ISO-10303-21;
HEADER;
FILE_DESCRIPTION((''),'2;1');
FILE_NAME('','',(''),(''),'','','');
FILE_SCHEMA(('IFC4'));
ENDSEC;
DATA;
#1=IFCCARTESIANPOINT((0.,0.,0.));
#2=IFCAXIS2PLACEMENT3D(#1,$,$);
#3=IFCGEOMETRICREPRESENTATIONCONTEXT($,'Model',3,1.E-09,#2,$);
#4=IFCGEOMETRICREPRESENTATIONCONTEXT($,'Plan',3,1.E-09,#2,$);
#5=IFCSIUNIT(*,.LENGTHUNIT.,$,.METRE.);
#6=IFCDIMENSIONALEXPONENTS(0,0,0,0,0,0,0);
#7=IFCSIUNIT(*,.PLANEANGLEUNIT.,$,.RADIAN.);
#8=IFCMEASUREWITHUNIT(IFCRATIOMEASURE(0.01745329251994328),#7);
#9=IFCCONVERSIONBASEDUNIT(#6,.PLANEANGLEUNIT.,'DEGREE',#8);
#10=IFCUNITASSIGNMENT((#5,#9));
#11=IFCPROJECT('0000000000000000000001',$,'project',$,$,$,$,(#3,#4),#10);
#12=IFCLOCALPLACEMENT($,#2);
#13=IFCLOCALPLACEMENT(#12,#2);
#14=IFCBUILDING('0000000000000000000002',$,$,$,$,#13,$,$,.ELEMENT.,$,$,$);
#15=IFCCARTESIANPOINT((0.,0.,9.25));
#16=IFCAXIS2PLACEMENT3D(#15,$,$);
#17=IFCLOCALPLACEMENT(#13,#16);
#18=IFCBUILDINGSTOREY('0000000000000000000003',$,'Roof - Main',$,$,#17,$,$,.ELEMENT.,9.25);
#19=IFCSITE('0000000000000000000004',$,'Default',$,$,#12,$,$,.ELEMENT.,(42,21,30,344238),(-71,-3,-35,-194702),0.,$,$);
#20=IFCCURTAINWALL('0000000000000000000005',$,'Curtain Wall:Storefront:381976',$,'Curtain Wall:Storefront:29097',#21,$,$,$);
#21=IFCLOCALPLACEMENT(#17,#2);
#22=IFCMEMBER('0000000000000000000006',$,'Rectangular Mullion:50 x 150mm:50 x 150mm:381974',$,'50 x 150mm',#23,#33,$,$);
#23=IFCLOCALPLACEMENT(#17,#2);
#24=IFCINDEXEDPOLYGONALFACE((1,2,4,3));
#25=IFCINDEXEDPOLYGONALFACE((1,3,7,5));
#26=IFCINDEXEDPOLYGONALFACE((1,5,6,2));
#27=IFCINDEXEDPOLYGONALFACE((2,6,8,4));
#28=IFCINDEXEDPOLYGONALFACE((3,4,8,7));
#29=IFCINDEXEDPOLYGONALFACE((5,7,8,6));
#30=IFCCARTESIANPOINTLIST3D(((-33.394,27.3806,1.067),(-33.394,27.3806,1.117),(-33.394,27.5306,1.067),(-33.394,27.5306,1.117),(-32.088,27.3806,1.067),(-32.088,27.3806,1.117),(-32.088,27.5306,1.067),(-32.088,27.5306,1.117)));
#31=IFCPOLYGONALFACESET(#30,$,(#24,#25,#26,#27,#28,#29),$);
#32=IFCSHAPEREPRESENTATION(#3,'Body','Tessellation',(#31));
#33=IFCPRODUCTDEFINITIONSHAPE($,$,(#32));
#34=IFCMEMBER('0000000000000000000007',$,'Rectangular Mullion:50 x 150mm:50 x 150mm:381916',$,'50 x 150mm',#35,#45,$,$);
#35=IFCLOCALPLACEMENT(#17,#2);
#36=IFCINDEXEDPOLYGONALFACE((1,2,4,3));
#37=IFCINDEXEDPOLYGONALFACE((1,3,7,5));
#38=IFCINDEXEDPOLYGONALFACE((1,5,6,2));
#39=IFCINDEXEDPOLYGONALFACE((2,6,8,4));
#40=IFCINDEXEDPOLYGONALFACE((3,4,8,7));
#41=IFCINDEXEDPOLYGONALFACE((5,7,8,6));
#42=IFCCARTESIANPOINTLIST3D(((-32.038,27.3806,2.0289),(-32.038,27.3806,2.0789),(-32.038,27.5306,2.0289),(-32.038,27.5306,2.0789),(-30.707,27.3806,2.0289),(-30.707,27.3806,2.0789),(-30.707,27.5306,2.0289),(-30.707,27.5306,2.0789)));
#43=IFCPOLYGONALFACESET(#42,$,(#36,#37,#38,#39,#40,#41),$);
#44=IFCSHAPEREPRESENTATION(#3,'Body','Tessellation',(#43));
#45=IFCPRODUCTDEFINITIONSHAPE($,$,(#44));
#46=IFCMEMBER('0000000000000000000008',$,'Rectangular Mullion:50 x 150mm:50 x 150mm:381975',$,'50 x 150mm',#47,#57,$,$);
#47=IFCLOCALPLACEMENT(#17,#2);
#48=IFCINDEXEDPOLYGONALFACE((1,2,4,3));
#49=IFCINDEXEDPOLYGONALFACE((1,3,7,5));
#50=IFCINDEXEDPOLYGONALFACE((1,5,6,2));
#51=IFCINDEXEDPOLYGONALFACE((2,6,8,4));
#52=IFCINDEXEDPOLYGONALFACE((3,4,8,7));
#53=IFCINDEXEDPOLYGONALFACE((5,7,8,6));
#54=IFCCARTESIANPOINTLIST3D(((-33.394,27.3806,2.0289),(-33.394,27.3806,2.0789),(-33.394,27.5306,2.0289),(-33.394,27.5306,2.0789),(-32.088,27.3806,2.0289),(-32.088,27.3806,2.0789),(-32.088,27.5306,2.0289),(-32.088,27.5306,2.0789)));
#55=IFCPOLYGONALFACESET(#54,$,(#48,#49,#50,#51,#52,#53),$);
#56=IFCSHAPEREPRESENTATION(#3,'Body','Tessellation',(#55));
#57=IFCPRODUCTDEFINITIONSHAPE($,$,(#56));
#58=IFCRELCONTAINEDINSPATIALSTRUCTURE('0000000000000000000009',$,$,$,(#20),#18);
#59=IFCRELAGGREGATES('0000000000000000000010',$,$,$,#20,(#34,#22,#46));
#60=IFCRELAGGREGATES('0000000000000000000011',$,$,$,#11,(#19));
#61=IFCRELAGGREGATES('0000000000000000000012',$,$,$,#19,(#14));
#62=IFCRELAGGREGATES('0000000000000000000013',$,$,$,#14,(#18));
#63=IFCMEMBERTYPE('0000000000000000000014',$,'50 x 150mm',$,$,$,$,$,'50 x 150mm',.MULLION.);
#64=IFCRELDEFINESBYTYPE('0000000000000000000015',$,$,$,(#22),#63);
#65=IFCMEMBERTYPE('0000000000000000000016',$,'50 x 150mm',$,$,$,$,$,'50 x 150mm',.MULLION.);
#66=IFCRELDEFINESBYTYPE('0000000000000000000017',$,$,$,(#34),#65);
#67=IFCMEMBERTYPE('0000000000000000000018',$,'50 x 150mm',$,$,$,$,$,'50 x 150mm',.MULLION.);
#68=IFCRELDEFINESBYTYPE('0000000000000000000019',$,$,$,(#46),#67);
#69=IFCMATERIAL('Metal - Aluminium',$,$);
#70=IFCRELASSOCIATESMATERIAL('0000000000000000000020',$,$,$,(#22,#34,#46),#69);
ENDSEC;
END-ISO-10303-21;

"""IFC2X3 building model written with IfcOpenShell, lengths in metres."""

from ifc_helpers import new_model, entity, si_unit, converted_unit, frame, origin, origin_2d_with_axis, place, context, project, spatial, rectangle, extrude, source, transform, mapped, material, type_object, type_shapes, element, aggregate, save


model = new_model("IFC2X3")

# Units and contexts
model_context = context("Model", 3, precision=1e-09, world=origin())
plan_context = context("Plan", 3, precision=1e-09, world=origin())
ifc_project = project(units=[si_unit("LENGTHUNIT", "METRE"), converted_unit("PLANEANGLEUNIT", "DEGREE", entity("IfcRatioMeasure", 0.01745329251994328), si_unit("PLANEANGLEUNIT", "RADIAN"), dimensions=[0, 0, 0, 0, 0, 0, 0])], contexts=[model_context, plan_context])

# Site, building, storey
site_placement = place(None, origin())
site = spatial("IfcSite", under=ifc_project, at=site_placement, Name="Default", CompositionType="ELEMENT", RefLatitude=(42, 21, 30, 344238), RefLongitude=(-71, -3, -35, -194702), RefElevation=0.0)
building_placement = place(site_placement, origin())
building = spatial("IfcBuilding", under=site, at=building_placement, CompositionType="ELEMENT")
storey_placement = place(building_placement, frame((0.0, 0.0, 9.25)))
storey = spatial("IfcBuildingStorey", under=building, at=storey_placement, Name="Roof - Main", CompositionType="ELEMENT", Elevation=9.25)

# Curtain wall
curtain_wall_1_placement = place(storey_placement, origin())
curtain_wall_1 = element("IfcCurtainWall", 1, at=curtain_wall_1_placement, inside=storey, Name="Curtain Wall:Storefront:381976", ObjectType="Curtain Wall:Storefront:29097")
ifc_material_1 = material(Name="Metal - Aluminium")

# Members
member_type_1 = type_object("IfcMemberType", Name="50 x 150mm", ElementType="50 x 150mm", PredefinedType="MULLION")
shared_shape_1 = source(origin(), model_context, "Body", "SweptSolid", [
    extrude(rectangle(XDim=0.05, YDim=0.15, at=origin_2d_with_axis()), frame((-0.025, 0.0, -1.306), z_axis=(0.0, 0.0, 1.0), x_axis=(-1.0, 0.0, 0.0)), (0.0, 0.0, 1.0), 1.306),
])
type_shapes(member_type_1, [shared_shape_1])
member_1_placement = place(storey_placement, frame((-33.394, 27.4556, 1.067), z_axis=(-1.0, 0.0, 0.0), x_axis=(0.0, 0.0, -1.0)))
member_1 = element("IfcMember", 2, at=member_1_placement, type_object=member_type_1, material=ifc_material_1, Name="Rectangular Mullion:50 x 150mm:50 x 150mm:381974", ObjectType="50 x 150mm", context=model_context, shape_type="MappedRepresentation", body=[
    mapped(shared_shape_1, transform((0.0, 0.0, 0.0), scale=1.0)),
])
member_type_2 = type_object("IfcMemberType", Name="50 x 150mm", ElementType="50 x 150mm", PredefinedType="MULLION")
shared_shape_2 = source(origin(), model_context, "Body", "SweptSolid", [
    extrude(rectangle(XDim=0.05, YDim=0.15, at=origin_2d_with_axis()), frame((0.0, 0.0, -1.331), z_axis=(0.0, 0.0, 1.0), x_axis=(-1.0, 0.0, 0.0)), (0.0, 0.0, 1.0), 1.331),
])
type_shapes(member_type_2, [shared_shape_2])
member_2_placement = place(storey_placement, frame((-30.707, 27.4556, 2.0539), z_axis=(1.0, 0.0, 0.0), x_axis=(0.0, 0.0, 1.0)))
member_2 = element("IfcMember", 3, at=member_2_placement, type_object=member_type_2, material=ifc_material_1, Name="Rectangular Mullion:50 x 150mm:50 x 150mm:381916", ObjectType="50 x 150mm", context=model_context, shape_type="MappedRepresentation", body=[
    mapped(shared_shape_2, transform((0.0, 0.0, 0.0), scale=1.0)),
])
member_type_3 = type_object("IfcMemberType", Name="50 x 150mm", ElementType="50 x 150mm", PredefinedType="MULLION")
shared_shape_3 = source(origin(), model_context, "Body", "SweptSolid", [
    extrude(rectangle(XDim=0.05, YDim=0.15, at=origin_2d_with_axis()), frame((0.0, 0.0, -1.306), z_axis=(0.0, 0.0, 1.0), x_axis=(-1.0, 0.0, 0.0)), (0.0, 0.0, 1.0), 1.306),
])
type_shapes(member_type_3, [shared_shape_3])
member_3_placement = place(storey_placement, frame((-32.088, 27.4556, 2.0539), z_axis=(1.0, 0.0, 0.0), x_axis=(0.0, 0.0, 1.0)))
member_3 = element("IfcMember", 4, at=member_3_placement, type_object=member_type_3, material=ifc_material_1, Name="Rectangular Mullion:50 x 150mm:50 x 150mm:381975", ObjectType="50 x 150mm", context=model_context, shape_type="MappedRepresentation", body=[
    mapped(shared_shape_3, transform((0.0, 0.0, 0.0), scale=1.0)),
])

aggregate(curtain_wall_1, [member_2, member_1, member_3])

save(model, "model.ifc")
